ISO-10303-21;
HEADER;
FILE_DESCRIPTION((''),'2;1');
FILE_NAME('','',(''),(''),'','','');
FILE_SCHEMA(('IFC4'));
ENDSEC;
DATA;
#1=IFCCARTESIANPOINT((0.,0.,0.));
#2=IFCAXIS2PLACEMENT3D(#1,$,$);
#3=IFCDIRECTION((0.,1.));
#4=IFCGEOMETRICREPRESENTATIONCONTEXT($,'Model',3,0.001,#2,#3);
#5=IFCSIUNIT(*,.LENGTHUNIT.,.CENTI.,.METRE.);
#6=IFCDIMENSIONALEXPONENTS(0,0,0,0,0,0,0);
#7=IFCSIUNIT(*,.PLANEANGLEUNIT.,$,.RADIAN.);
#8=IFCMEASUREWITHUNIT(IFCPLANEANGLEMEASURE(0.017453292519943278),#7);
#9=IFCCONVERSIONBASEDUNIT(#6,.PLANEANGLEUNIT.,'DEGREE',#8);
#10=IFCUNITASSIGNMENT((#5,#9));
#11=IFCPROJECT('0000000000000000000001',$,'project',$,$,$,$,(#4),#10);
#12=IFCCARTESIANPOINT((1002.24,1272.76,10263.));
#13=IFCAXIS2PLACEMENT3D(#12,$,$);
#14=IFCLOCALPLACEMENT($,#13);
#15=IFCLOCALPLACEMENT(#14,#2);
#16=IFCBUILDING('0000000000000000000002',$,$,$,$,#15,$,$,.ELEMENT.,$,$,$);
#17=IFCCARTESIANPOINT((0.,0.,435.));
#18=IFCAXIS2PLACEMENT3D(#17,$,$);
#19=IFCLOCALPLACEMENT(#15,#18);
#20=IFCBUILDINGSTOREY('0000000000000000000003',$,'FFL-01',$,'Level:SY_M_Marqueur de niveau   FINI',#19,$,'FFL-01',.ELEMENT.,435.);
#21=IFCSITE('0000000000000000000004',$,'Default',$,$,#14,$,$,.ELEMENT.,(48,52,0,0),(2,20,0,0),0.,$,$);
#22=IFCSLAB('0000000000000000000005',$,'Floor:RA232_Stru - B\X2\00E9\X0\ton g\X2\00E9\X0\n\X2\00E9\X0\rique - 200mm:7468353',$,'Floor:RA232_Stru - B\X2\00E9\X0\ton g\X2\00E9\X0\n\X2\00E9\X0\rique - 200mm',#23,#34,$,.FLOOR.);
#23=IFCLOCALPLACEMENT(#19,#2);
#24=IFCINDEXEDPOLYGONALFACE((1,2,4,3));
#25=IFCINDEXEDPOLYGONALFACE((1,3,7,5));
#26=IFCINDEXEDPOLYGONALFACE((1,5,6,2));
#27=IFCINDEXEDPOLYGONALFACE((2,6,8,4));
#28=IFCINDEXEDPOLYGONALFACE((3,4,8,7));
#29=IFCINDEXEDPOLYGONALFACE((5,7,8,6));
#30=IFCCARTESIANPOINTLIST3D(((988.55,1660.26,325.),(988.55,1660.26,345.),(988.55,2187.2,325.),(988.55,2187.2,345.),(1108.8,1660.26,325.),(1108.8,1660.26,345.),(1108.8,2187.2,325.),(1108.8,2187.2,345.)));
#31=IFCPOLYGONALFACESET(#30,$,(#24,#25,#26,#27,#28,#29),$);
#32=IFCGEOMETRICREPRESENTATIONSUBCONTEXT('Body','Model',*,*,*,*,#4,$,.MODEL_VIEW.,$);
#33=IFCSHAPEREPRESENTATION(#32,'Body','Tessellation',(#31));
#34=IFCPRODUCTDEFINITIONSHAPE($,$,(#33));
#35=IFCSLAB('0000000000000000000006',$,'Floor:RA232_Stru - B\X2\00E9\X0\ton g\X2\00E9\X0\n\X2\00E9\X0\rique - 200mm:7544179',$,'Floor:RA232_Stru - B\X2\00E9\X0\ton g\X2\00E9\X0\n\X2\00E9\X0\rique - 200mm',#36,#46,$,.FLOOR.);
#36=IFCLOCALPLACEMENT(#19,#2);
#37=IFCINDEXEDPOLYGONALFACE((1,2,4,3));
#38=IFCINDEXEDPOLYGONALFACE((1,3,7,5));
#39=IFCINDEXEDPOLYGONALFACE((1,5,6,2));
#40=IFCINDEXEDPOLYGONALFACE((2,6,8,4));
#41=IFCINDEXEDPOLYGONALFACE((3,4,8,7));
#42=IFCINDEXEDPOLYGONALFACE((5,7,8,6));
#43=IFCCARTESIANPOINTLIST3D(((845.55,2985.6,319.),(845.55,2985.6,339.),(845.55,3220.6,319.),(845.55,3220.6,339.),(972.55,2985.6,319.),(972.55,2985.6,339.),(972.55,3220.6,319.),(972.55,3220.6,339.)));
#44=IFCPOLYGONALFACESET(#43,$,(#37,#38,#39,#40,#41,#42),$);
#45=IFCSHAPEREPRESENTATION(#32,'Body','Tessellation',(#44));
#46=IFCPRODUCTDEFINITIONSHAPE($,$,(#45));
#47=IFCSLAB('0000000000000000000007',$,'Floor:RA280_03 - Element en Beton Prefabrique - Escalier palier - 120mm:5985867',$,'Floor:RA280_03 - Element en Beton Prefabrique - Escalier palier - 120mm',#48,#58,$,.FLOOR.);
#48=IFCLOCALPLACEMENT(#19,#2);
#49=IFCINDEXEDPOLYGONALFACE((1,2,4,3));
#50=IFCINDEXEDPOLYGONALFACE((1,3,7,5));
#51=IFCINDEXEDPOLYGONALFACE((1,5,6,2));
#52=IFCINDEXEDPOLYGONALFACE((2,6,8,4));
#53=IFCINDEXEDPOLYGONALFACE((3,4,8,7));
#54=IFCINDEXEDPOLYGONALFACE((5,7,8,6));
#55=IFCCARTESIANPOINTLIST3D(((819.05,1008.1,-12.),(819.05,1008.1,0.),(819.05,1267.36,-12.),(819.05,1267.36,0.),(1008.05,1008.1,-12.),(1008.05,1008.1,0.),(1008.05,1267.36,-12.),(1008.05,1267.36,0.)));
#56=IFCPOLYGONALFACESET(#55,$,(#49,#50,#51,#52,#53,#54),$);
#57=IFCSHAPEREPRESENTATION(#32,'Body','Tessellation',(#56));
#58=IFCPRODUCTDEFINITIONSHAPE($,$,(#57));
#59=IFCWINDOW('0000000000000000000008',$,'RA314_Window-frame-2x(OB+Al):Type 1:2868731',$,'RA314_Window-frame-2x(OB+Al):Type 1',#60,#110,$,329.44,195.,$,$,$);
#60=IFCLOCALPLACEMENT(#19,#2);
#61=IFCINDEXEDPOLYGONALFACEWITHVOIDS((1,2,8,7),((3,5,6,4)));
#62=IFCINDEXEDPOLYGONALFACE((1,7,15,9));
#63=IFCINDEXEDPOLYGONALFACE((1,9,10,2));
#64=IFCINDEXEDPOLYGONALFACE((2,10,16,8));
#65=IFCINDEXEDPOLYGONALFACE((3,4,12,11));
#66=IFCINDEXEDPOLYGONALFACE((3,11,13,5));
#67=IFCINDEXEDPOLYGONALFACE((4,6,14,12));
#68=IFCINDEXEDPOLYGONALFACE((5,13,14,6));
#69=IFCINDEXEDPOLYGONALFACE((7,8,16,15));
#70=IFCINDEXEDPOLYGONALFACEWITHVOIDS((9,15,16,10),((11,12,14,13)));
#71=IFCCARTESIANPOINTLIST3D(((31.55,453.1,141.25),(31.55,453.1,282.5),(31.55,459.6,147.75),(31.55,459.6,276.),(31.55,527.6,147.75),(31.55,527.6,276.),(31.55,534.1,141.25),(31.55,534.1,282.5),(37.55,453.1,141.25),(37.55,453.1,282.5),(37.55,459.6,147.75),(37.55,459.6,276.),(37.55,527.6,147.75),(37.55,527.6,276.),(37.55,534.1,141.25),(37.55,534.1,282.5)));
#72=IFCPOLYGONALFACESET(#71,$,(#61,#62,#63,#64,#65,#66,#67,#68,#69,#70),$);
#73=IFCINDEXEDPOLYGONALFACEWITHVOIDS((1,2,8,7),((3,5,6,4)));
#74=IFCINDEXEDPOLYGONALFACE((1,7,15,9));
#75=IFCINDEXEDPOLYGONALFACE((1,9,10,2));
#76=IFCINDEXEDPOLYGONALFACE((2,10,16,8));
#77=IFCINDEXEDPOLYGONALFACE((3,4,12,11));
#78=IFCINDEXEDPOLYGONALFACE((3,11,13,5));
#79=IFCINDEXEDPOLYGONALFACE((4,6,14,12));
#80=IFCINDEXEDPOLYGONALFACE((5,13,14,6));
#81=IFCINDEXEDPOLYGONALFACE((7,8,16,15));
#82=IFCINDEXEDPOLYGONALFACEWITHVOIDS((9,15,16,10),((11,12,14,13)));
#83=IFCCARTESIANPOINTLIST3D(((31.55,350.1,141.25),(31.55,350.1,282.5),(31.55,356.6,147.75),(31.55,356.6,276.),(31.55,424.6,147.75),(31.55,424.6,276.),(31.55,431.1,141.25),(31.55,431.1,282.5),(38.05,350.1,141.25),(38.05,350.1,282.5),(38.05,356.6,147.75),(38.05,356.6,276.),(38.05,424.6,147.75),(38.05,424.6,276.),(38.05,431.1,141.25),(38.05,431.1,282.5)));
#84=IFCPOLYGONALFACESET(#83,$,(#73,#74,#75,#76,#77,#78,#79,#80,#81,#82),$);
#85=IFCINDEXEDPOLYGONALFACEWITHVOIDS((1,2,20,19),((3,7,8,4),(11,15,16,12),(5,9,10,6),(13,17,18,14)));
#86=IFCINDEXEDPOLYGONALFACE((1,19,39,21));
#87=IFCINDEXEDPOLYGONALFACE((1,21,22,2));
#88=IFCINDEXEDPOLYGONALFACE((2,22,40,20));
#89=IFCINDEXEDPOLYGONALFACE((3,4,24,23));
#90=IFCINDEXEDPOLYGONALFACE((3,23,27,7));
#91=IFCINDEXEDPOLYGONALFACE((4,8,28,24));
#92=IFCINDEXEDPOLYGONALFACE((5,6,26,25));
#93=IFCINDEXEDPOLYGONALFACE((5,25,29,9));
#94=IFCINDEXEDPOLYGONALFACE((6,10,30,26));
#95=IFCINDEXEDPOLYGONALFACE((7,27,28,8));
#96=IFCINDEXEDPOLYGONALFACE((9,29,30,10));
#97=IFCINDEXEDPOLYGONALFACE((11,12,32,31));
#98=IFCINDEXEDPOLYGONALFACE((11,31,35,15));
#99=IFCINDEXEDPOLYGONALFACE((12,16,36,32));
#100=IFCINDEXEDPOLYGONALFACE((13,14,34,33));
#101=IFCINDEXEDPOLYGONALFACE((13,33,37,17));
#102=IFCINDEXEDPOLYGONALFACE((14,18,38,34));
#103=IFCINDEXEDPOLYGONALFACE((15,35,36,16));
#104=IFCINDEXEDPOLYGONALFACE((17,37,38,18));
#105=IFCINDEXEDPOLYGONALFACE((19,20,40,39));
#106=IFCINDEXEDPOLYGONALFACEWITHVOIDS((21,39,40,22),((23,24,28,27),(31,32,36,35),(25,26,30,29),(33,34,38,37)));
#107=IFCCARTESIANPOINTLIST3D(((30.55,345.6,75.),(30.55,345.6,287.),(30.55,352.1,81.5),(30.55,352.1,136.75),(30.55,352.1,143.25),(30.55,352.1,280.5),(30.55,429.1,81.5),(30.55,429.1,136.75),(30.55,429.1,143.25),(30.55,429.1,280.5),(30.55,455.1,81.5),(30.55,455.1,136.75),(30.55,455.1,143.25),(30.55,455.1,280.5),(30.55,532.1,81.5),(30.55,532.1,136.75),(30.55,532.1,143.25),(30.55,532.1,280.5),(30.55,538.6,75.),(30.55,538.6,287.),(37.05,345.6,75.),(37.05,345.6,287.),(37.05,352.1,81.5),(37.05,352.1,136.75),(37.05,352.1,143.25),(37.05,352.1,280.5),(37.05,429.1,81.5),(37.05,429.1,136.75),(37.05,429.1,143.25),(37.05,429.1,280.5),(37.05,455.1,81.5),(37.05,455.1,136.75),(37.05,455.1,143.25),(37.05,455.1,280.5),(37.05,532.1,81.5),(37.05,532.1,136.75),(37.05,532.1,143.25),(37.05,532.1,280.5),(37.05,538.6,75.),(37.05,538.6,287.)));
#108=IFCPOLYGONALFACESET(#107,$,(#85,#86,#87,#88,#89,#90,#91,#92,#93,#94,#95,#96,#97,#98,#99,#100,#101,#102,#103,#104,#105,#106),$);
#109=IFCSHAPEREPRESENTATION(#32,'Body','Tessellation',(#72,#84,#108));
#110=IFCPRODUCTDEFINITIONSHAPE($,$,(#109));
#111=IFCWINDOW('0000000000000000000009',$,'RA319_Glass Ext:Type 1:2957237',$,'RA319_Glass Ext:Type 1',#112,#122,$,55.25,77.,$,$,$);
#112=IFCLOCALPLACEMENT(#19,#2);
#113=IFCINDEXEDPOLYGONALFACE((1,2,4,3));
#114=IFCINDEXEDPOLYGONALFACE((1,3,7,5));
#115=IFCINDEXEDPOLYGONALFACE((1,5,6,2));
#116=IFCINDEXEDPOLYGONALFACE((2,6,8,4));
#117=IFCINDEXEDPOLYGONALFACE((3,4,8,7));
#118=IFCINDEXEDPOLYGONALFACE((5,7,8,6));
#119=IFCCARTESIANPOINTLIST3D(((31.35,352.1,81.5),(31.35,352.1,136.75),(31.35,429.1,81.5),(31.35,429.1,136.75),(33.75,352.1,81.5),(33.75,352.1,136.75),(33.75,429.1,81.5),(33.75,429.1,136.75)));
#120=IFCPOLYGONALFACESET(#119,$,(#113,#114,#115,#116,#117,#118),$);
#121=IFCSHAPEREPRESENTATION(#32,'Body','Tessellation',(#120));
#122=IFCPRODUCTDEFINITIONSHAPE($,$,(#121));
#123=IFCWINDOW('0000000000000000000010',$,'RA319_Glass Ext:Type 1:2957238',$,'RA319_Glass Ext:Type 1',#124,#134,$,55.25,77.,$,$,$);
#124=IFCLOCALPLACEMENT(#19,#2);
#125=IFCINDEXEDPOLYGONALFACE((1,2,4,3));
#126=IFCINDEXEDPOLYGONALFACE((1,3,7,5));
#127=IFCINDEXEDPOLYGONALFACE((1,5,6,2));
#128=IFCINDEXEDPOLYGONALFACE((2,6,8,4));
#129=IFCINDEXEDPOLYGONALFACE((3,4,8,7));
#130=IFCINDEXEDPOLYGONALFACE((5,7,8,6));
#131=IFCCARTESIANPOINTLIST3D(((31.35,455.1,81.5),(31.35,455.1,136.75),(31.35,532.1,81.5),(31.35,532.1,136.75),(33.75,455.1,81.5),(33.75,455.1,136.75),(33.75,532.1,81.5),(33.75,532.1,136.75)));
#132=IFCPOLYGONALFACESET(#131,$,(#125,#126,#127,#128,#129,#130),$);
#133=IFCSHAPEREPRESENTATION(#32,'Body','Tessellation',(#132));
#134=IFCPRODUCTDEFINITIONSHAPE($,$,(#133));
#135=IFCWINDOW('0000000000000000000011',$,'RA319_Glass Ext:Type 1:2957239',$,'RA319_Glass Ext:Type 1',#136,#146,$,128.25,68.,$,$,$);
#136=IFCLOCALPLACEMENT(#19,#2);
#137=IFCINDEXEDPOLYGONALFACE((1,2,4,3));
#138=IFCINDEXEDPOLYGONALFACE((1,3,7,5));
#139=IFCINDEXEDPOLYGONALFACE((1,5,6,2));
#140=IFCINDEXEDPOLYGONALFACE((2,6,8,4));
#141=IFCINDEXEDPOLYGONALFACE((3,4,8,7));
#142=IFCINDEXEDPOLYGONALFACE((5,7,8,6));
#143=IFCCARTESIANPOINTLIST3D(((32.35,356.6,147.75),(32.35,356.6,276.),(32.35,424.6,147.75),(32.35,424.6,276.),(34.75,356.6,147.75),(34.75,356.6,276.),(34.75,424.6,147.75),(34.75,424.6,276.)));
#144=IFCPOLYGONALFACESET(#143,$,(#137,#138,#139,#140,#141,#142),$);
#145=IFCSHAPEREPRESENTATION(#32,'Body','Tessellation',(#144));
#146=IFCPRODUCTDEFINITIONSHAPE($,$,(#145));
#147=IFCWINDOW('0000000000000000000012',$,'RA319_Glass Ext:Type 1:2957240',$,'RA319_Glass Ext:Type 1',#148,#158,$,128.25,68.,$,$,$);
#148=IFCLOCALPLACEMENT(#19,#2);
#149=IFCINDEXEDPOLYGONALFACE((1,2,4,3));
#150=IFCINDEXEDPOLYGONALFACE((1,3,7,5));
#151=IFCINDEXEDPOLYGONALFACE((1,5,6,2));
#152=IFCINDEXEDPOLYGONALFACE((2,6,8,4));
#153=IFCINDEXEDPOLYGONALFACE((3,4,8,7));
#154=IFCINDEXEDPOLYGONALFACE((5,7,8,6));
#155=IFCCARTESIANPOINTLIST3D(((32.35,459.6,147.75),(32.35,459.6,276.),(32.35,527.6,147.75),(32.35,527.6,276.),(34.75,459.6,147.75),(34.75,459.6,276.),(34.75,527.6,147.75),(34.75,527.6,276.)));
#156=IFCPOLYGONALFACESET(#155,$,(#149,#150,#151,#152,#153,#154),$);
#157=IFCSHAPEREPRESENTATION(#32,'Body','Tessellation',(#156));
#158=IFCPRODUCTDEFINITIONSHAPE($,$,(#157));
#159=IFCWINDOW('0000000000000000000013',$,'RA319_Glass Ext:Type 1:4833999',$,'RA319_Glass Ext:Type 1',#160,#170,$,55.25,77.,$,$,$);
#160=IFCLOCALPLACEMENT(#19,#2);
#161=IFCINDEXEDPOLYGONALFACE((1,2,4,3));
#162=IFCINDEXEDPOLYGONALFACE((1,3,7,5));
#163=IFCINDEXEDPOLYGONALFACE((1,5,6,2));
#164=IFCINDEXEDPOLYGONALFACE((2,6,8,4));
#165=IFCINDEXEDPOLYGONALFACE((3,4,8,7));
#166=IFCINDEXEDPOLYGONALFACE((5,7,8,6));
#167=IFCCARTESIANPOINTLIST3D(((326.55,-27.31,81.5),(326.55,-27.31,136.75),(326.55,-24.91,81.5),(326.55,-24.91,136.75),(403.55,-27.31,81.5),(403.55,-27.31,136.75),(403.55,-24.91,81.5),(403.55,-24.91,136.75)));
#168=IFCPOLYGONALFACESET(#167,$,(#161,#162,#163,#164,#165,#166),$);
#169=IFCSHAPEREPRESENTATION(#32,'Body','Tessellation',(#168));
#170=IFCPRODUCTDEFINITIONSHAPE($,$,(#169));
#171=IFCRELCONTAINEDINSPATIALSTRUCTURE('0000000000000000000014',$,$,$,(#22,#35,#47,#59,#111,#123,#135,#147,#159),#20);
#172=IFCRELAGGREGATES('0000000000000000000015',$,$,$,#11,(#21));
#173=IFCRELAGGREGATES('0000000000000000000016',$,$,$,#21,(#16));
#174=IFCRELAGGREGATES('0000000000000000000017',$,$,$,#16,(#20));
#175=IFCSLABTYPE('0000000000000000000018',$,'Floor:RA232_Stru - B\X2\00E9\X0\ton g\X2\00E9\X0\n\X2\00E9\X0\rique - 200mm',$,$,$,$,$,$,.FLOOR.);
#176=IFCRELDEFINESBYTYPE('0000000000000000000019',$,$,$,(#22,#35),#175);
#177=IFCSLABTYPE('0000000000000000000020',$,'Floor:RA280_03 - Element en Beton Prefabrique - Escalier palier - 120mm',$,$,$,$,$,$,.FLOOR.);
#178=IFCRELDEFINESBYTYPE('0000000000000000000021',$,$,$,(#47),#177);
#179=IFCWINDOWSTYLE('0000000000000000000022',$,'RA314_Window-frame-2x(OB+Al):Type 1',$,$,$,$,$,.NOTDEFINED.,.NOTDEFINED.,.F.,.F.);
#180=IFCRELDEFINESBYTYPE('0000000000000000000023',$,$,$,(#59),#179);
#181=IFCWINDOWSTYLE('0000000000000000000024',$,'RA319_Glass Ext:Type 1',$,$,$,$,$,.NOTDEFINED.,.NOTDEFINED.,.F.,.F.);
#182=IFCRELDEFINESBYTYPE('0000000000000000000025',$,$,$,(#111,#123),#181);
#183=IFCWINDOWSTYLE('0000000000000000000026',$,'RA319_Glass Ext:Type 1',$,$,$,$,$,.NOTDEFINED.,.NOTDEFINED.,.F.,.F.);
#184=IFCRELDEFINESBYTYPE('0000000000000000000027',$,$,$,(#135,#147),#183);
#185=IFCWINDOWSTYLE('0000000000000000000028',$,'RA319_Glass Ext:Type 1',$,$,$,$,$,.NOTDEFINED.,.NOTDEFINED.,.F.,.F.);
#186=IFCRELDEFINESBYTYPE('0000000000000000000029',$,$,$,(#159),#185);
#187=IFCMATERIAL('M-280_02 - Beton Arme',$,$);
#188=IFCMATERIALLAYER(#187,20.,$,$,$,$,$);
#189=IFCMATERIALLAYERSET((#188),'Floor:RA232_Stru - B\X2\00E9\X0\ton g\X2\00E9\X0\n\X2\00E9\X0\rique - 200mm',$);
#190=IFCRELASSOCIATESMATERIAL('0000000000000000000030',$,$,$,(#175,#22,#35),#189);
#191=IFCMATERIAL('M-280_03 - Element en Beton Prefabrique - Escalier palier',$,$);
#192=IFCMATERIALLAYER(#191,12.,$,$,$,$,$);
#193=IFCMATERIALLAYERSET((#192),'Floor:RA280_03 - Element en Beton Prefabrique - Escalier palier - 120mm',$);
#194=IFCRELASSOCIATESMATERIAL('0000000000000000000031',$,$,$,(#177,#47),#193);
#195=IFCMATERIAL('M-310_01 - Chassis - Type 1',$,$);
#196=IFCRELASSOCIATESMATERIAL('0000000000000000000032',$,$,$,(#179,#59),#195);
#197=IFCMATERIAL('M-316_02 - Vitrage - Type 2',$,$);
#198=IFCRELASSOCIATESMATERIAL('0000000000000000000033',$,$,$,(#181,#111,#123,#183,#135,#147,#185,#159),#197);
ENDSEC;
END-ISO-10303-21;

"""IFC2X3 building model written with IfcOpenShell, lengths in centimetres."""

from ifc_helpers import new_model, entity, si_unit, converted_unit, direction, frame, frame_2d, origin, place, context, subcontext, project, spatial, polyline, rectangle, outline, extrude, source, transform, mapped, material, layer, layer_set, layer_usage, type_object, type_shapes, element, save


model = new_model("IFC2X3")

# Units and contexts
model_context = context("Model", 3, precision=0.001, world=origin(), true_north=direction((0.0, 1.0)))
body_context = subcontext(model_context, "Body", "Model", "MODEL_VIEW")
ifc_project = project(units=[si_unit("LENGTHUNIT", "METRE", prefix="CENTI"), converted_unit("PLANEANGLEUNIT", "DEGREE", entity("IfcPlaneAngleMeasure", 0.017453292519943278), si_unit("PLANEANGLEUNIT", "RADIAN"), dimensions=[0, 0, 0, 0, 0, 0, 0])], contexts=[model_context])

# Site, building, storey
site_placement = place(None, frame((1002.24, 1272.76, 10263.0)))
site = spatial("IfcSite", under=ifc_project, at=site_placement, Name="Default", CompositionType="ELEMENT", RefLatitude=(48, 52, 0, 0), RefLongitude=(2, 20, 0, 0), RefElevation=0.0)
building_placement = place(site_placement, origin())
building = spatial("IfcBuilding", under=site, at=building_placement, CompositionType="ELEMENT")
storey_placement = place(building_placement, frame((0.0, 0.0, 435.0)))
storey = spatial("IfcBuildingStorey", under=building, at=storey_placement, Name="FFL-01", ObjectType="Level:SY_M_Marqueur de niveau   FINI", LongName="FFL-01", CompositionType="ELEMENT", Elevation=435.0)

# Shared definitions
ifc_material_1 = material(Name="M-280_02 - Beton Arme")
ifc_layer_1 = layer(ifc_material_1, 20.0)
ifc_layer_set_1 = layer_set([ifc_layer_1], Name="Floor:RA232_Stru - Béton générique - 200mm")
slab_type_1 = type_object("IfcSlabType", Name="Floor:RA232_Stru - Béton générique - 200mm", PredefinedType="FLOOR", material=ifc_layer_set_1)

# Slabs
ifc_layer_usage_1 = layer_usage(ifc_layer_set_1, "AXIS3", "POSITIVE", 0.0)
slab_1_placement = place(storey_placement, origin())
element("IfcSlab", 1, at=slab_1_placement, inside=storey, type_object=slab_type_1, material=ifc_layer_usage_1, Name="Floor:RA232_Stru - Béton générique - 200mm:7468353", ObjectType="Floor:RA232_Stru - Béton générique - 200mm", PredefinedType="FLOOR", context=body_context, shape_type="SweptSolid", body=[
    extrude(outline(polyline([(-263.47, -60.12), (263.47, -60.12), (263.47, 60.12), (-263.47, 60.13), (-263.47, -60.12)])), frame((1048.67, 1923.73, 345.0), z_axis=(0.0, 0.0, -1.0), x_axis=(0.0, 1.0, 0.0)), (0.0, 0.0, 1.0), 20.0),
])
ifc_layer_usage_2 = layer_usage(ifc_layer_set_1, "AXIS3", "POSITIVE", 0.0)
slab_2_placement = place(storey_placement, origin())
element("IfcSlab", 2, at=slab_2_placement, inside=storey, type_object=slab_type_1, material=ifc_layer_usage_2, Name="Floor:RA232_Stru - Béton générique - 200mm:7544179", ObjectType="Floor:RA232_Stru - Béton générique - 200mm", PredefinedType="FLOOR", context=body_context, shape_type="SweptSolid", body=[
    extrude(rectangle(XDim=235.0, YDim=126.99, at=frame_2d((0.0, 0.0), x_axis=(1.0, 0.0))), frame((909.05, 3103.1, 339.0), z_axis=(0.0, 0.0, -1.0), x_axis=(0.0, 1.0, 0.0)), (0.0, 0.0, 1.0), 20.0),
])

# Shared definitions
ifc_material_2 = material(Name="M-280_03 - Element en Beton Prefabrique - Escalier palier")

# Slab
ifc_layer_2 = layer(ifc_material_2, 12.0)
ifc_layer_set_2 = layer_set([ifc_layer_2], Name="Floor:RA280_03 - Element en Beton Prefabrique - Escalier palier - 120mm")
ifc_layer_usage_3 = layer_usage(ifc_layer_set_2, "AXIS3", "POSITIVE", 0.0)
slab_type_2 = type_object("IfcSlabType", Name="Floor:RA280_03 - Element en Beton Prefabrique - Escalier palier - 120mm", PredefinedType="FLOOR", material=ifc_layer_set_2)
slab_3_placement = place(storey_placement, origin())
element("IfcSlab", 3, at=slab_3_placement, inside=storey, type_object=slab_type_2, material=ifc_layer_usage_3, Name="Floor:RA280_03 - Element en Beton Prefabrique - Escalier palier - 120mm:5985867", ObjectType="Floor:RA280_03 - Element en Beton Prefabrique - Escalier palier - 120mm", PredefinedType="FLOOR", context=body_context, shape_type="SweptSolid", body=[
    extrude(rectangle(XDim=259.26, YDim=189.0, at=frame_2d((0.0, 0.0), x_axis=(1.0, 0.0))), frame((913.55, 1137.73, 0.0), z_axis=(0.0, 0.0, -1.0), x_axis=(0.0, 1.0, 0.0)), (0.0, 0.0, 1.0), 12.0),
])

# Windows
ifc_material_3 = material(Name="M-310_01 - Chassis - Type 1")
window_style_1 = type_object("IfcWindowStyle", Name="RA314_Window-frame-2x(OB+Al):Type 1", ConstructionType="NOTDEFINED", OperationType="NOTDEFINED", ParameterTakesPrecedence=False, Sizeable=False, material=ifc_material_3)
shared_shape_1 = source(origin(), body_context, "Body", "SweptSolid", [
    extrude(outline(polyline([(-70.62, -40.5), (70.62, -40.5), (70.62, 40.5), (-70.62, 40.5), (-70.62, -40.5)]), holes=[polyline([(-64.12, -34.0), (-64.12, 34.0), (64.12, 34.0), (64.12, -34.0), (-64.12, -34.0)])]), frame((51.5, -7.0, 136.87), z_axis=(0.0, 1.0, 0.0), x_axis=(0.0, 0.0, -1.0)), (0.0, 0.0, 1.0), 6.0),
    extrude(outline(polyline([(-70.62, -40.5), (70.62, -40.5), (70.62, 40.5), (-70.62, 40.5), (-70.62, -40.5)]), holes=[polyline([(-64.12, -34.0), (-64.12, 34.0), (64.12, 34.0), (64.12, -34.0), (-64.12, -34.0)])]), frame((-51.5, -7.5, 136.87), z_axis=(0.0, 1.0, 0.0), x_axis=(0.0, 0.0, -1.0)), (0.0, 0.0, 1.0), 6.5),
    extrude(outline(polyline([(-106.0, -96.5), (106.0, -96.5), (106.0, 96.5), (-106.0, 96.5), (-106.0, -96.5)]), holes=[polyline([(44.25, 13.0), (44.25, 90.0), (99.5, 90.0), (99.5, 13.0), (44.25, 13.0)]), polyline([(44.25, -90.0), (44.25, -13.0), (99.5, -13.0), (99.5, -90.0), (44.25, -90.0)]), polyline([(-99.5, 13.0), (-99.5, 90.0), (37.75, 90.0), (37.75, 13.0), (-99.5, 13.0)]), polyline([(-99.5, -90.0), (-99.5, -13.0), (37.75, -13.0), (37.75, -90.0), (-99.5, -90.0)])]), frame((0.0, -6.5, 106.0), z_axis=(0.0, 1.0, 0.0), x_axis=(0.0, 0.0, -1.0)), (0.0, 0.0, 1.0), 6.5),
])
type_shapes(window_style_1, [shared_shape_1])
window_1_placement = place(storey_placement, frame((30.55, 442.1, 75.0), z_axis=(0.0, 0.0, 1.0), x_axis=(0.0, 1.0, 0.0)))
element("IfcWindow", 4, at=window_1_placement, inside=storey, type_object=window_style_1, material=ifc_material_3, Name="RA314_Window-frame-2x(OB+Al):Type 1:2868731", ObjectType="RA314_Window-frame-2x(OB+Al):Type 1", OverallHeight=329.44, OverallWidth=195.0, context=body_context, shape_type="MappedRepresentation", body=[
    mapped(shared_shape_1, transform((0.0, 0.0, 0.0), scale=1.0)),
])
ifc_material_4 = material(Name="M-316_02 - Vitrage - Type 2")
window_style_2 = type_object("IfcWindowStyle", Name="RA319_Glass Ext:Type 1", ConstructionType="NOTDEFINED", OperationType="NOTDEFINED", ParameterTakesPrecedence=False, Sizeable=False, material=ifc_material_4)
shared_shape_2 = source(origin(), body_context, "Body", "SweptSolid", [
    extrude(rectangle(XDim=55.25, YDim=77.0, at=frame_2d((0.0, 0.0), x_axis=(1.0, 0.0))), frame((0.0, 0.0, 0.0), z_axis=(0.0, 0.0, 1.0), x_axis=(0.0, 1.0, 0.0)), (0.0, 0.0, 1.0), 2.4),
])
type_shapes(window_style_2, [shared_shape_2])
for number, where, z_axis, x_axis, name in (
    (5, (31.35, 390.6, 109.12), (1.0, 0.0, 0.0), (0.0, -1.0, 0.0), "RA319_Glass Ext:Type 1:2957237"),
    (6, (31.35, 493.6, 109.12), (1.0, 0.0, 0.0), (0.0, -1.0, 0.0), "RA319_Glass Ext:Type 1:2957238"),
):
    element("IfcWindow", number, at=place(storey_placement, frame(where, z_axis=z_axis, x_axis=x_axis)), inside=storey, type_object=window_style_2, material=ifc_material_4, Name=name, ObjectType="RA319_Glass Ext:Type 1", OverallHeight=55.25, OverallWidth=77.0, context=body_context, shape_type="MappedRepresentation", body=[
        mapped(shared_shape_2, transform((0.0, 0.0, 0.0), scale=1.0)),
    ])
window_style_3 = type_object("IfcWindowStyle", Name="RA319_Glass Ext:Type 1", ConstructionType="NOTDEFINED", OperationType="NOTDEFINED", ParameterTakesPrecedence=False, Sizeable=False, material=ifc_material_4)
shared_shape_3 = source(origin(), body_context, "Body", "SweptSolid", [
    extrude(rectangle(XDim=128.25, YDim=68.0, at=frame_2d((0.0, 0.0), x_axis=(1.0, 0.0))), frame((0.0, 0.0, 0.0), z_axis=(0.0, 0.0, 1.0), x_axis=(0.0, 1.0, 0.0)), (0.0, 0.0, 1.0), 2.4),
])
type_shapes(window_style_3, [shared_shape_3])
for number, where, z_axis, x_axis, name in (
    (7, (32.35, 390.6, 211.87), (1.0, 0.0, 0.0), (0.0, -1.0, 0.0), "RA319_Glass Ext:Type 1:2957239"),
    (8, (32.35, 493.6, 211.87), (1.0, 0.0, 0.0), (0.0, -1.0, 0.0), "RA319_Glass Ext:Type 1:2957240"),
):
    element("IfcWindow", number, at=place(storey_placement, frame(where, z_axis=z_axis, x_axis=x_axis)), inside=storey, type_object=window_style_3, material=ifc_material_4, Name=name, ObjectType="RA319_Glass Ext:Type 1", OverallHeight=128.25, OverallWidth=68.0, context=body_context, shape_type="MappedRepresentation", body=[
        mapped(shared_shape_3, transform((0.0, 0.0, 0.0), scale=1.0)),
    ])
window_style_4 = type_object("IfcWindowStyle", Name="RA319_Glass Ext:Type 1", ConstructionType="NOTDEFINED", OperationType="NOTDEFINED", ParameterTakesPrecedence=False, Sizeable=False, material=ifc_material_4)
shared_shape_4 = source(origin(), body_context, "Body", "SweptSolid", [
    extrude(rectangle(XDim=77.0, YDim=55.25, at=frame_2d((0.0, 0.0), x_axis=(1.0, 0.0))), frame((0.0, 0.0, 0.0), z_axis=(0.0, 0.0, 1.0), x_axis=(-1.0, 0.0, 0.0)), (0.0, 0.0, 1.0), 2.4),
])
type_shapes(window_style_4, [shared_shape_4])
window_2_placement = place(storey_placement, frame((365.05, -27.31, 109.13), z_axis=(0.0, 1.0, 0.0), x_axis=(-1.0, 0.0, 0.0)))
element("IfcWindow", 9, at=window_2_placement, inside=storey, type_object=window_style_4, material=ifc_material_4, Name="RA319_Glass Ext:Type 1:4833999", ObjectType="RA319_Glass Ext:Type 1", OverallHeight=55.25, OverallWidth=77.0, context=body_context, shape_type="MappedRepresentation", body=[
    mapped(shared_shape_4, transform((0.0, 0.0, 0.0), scale=1.0)),
])

save(model, "model.ifc")
